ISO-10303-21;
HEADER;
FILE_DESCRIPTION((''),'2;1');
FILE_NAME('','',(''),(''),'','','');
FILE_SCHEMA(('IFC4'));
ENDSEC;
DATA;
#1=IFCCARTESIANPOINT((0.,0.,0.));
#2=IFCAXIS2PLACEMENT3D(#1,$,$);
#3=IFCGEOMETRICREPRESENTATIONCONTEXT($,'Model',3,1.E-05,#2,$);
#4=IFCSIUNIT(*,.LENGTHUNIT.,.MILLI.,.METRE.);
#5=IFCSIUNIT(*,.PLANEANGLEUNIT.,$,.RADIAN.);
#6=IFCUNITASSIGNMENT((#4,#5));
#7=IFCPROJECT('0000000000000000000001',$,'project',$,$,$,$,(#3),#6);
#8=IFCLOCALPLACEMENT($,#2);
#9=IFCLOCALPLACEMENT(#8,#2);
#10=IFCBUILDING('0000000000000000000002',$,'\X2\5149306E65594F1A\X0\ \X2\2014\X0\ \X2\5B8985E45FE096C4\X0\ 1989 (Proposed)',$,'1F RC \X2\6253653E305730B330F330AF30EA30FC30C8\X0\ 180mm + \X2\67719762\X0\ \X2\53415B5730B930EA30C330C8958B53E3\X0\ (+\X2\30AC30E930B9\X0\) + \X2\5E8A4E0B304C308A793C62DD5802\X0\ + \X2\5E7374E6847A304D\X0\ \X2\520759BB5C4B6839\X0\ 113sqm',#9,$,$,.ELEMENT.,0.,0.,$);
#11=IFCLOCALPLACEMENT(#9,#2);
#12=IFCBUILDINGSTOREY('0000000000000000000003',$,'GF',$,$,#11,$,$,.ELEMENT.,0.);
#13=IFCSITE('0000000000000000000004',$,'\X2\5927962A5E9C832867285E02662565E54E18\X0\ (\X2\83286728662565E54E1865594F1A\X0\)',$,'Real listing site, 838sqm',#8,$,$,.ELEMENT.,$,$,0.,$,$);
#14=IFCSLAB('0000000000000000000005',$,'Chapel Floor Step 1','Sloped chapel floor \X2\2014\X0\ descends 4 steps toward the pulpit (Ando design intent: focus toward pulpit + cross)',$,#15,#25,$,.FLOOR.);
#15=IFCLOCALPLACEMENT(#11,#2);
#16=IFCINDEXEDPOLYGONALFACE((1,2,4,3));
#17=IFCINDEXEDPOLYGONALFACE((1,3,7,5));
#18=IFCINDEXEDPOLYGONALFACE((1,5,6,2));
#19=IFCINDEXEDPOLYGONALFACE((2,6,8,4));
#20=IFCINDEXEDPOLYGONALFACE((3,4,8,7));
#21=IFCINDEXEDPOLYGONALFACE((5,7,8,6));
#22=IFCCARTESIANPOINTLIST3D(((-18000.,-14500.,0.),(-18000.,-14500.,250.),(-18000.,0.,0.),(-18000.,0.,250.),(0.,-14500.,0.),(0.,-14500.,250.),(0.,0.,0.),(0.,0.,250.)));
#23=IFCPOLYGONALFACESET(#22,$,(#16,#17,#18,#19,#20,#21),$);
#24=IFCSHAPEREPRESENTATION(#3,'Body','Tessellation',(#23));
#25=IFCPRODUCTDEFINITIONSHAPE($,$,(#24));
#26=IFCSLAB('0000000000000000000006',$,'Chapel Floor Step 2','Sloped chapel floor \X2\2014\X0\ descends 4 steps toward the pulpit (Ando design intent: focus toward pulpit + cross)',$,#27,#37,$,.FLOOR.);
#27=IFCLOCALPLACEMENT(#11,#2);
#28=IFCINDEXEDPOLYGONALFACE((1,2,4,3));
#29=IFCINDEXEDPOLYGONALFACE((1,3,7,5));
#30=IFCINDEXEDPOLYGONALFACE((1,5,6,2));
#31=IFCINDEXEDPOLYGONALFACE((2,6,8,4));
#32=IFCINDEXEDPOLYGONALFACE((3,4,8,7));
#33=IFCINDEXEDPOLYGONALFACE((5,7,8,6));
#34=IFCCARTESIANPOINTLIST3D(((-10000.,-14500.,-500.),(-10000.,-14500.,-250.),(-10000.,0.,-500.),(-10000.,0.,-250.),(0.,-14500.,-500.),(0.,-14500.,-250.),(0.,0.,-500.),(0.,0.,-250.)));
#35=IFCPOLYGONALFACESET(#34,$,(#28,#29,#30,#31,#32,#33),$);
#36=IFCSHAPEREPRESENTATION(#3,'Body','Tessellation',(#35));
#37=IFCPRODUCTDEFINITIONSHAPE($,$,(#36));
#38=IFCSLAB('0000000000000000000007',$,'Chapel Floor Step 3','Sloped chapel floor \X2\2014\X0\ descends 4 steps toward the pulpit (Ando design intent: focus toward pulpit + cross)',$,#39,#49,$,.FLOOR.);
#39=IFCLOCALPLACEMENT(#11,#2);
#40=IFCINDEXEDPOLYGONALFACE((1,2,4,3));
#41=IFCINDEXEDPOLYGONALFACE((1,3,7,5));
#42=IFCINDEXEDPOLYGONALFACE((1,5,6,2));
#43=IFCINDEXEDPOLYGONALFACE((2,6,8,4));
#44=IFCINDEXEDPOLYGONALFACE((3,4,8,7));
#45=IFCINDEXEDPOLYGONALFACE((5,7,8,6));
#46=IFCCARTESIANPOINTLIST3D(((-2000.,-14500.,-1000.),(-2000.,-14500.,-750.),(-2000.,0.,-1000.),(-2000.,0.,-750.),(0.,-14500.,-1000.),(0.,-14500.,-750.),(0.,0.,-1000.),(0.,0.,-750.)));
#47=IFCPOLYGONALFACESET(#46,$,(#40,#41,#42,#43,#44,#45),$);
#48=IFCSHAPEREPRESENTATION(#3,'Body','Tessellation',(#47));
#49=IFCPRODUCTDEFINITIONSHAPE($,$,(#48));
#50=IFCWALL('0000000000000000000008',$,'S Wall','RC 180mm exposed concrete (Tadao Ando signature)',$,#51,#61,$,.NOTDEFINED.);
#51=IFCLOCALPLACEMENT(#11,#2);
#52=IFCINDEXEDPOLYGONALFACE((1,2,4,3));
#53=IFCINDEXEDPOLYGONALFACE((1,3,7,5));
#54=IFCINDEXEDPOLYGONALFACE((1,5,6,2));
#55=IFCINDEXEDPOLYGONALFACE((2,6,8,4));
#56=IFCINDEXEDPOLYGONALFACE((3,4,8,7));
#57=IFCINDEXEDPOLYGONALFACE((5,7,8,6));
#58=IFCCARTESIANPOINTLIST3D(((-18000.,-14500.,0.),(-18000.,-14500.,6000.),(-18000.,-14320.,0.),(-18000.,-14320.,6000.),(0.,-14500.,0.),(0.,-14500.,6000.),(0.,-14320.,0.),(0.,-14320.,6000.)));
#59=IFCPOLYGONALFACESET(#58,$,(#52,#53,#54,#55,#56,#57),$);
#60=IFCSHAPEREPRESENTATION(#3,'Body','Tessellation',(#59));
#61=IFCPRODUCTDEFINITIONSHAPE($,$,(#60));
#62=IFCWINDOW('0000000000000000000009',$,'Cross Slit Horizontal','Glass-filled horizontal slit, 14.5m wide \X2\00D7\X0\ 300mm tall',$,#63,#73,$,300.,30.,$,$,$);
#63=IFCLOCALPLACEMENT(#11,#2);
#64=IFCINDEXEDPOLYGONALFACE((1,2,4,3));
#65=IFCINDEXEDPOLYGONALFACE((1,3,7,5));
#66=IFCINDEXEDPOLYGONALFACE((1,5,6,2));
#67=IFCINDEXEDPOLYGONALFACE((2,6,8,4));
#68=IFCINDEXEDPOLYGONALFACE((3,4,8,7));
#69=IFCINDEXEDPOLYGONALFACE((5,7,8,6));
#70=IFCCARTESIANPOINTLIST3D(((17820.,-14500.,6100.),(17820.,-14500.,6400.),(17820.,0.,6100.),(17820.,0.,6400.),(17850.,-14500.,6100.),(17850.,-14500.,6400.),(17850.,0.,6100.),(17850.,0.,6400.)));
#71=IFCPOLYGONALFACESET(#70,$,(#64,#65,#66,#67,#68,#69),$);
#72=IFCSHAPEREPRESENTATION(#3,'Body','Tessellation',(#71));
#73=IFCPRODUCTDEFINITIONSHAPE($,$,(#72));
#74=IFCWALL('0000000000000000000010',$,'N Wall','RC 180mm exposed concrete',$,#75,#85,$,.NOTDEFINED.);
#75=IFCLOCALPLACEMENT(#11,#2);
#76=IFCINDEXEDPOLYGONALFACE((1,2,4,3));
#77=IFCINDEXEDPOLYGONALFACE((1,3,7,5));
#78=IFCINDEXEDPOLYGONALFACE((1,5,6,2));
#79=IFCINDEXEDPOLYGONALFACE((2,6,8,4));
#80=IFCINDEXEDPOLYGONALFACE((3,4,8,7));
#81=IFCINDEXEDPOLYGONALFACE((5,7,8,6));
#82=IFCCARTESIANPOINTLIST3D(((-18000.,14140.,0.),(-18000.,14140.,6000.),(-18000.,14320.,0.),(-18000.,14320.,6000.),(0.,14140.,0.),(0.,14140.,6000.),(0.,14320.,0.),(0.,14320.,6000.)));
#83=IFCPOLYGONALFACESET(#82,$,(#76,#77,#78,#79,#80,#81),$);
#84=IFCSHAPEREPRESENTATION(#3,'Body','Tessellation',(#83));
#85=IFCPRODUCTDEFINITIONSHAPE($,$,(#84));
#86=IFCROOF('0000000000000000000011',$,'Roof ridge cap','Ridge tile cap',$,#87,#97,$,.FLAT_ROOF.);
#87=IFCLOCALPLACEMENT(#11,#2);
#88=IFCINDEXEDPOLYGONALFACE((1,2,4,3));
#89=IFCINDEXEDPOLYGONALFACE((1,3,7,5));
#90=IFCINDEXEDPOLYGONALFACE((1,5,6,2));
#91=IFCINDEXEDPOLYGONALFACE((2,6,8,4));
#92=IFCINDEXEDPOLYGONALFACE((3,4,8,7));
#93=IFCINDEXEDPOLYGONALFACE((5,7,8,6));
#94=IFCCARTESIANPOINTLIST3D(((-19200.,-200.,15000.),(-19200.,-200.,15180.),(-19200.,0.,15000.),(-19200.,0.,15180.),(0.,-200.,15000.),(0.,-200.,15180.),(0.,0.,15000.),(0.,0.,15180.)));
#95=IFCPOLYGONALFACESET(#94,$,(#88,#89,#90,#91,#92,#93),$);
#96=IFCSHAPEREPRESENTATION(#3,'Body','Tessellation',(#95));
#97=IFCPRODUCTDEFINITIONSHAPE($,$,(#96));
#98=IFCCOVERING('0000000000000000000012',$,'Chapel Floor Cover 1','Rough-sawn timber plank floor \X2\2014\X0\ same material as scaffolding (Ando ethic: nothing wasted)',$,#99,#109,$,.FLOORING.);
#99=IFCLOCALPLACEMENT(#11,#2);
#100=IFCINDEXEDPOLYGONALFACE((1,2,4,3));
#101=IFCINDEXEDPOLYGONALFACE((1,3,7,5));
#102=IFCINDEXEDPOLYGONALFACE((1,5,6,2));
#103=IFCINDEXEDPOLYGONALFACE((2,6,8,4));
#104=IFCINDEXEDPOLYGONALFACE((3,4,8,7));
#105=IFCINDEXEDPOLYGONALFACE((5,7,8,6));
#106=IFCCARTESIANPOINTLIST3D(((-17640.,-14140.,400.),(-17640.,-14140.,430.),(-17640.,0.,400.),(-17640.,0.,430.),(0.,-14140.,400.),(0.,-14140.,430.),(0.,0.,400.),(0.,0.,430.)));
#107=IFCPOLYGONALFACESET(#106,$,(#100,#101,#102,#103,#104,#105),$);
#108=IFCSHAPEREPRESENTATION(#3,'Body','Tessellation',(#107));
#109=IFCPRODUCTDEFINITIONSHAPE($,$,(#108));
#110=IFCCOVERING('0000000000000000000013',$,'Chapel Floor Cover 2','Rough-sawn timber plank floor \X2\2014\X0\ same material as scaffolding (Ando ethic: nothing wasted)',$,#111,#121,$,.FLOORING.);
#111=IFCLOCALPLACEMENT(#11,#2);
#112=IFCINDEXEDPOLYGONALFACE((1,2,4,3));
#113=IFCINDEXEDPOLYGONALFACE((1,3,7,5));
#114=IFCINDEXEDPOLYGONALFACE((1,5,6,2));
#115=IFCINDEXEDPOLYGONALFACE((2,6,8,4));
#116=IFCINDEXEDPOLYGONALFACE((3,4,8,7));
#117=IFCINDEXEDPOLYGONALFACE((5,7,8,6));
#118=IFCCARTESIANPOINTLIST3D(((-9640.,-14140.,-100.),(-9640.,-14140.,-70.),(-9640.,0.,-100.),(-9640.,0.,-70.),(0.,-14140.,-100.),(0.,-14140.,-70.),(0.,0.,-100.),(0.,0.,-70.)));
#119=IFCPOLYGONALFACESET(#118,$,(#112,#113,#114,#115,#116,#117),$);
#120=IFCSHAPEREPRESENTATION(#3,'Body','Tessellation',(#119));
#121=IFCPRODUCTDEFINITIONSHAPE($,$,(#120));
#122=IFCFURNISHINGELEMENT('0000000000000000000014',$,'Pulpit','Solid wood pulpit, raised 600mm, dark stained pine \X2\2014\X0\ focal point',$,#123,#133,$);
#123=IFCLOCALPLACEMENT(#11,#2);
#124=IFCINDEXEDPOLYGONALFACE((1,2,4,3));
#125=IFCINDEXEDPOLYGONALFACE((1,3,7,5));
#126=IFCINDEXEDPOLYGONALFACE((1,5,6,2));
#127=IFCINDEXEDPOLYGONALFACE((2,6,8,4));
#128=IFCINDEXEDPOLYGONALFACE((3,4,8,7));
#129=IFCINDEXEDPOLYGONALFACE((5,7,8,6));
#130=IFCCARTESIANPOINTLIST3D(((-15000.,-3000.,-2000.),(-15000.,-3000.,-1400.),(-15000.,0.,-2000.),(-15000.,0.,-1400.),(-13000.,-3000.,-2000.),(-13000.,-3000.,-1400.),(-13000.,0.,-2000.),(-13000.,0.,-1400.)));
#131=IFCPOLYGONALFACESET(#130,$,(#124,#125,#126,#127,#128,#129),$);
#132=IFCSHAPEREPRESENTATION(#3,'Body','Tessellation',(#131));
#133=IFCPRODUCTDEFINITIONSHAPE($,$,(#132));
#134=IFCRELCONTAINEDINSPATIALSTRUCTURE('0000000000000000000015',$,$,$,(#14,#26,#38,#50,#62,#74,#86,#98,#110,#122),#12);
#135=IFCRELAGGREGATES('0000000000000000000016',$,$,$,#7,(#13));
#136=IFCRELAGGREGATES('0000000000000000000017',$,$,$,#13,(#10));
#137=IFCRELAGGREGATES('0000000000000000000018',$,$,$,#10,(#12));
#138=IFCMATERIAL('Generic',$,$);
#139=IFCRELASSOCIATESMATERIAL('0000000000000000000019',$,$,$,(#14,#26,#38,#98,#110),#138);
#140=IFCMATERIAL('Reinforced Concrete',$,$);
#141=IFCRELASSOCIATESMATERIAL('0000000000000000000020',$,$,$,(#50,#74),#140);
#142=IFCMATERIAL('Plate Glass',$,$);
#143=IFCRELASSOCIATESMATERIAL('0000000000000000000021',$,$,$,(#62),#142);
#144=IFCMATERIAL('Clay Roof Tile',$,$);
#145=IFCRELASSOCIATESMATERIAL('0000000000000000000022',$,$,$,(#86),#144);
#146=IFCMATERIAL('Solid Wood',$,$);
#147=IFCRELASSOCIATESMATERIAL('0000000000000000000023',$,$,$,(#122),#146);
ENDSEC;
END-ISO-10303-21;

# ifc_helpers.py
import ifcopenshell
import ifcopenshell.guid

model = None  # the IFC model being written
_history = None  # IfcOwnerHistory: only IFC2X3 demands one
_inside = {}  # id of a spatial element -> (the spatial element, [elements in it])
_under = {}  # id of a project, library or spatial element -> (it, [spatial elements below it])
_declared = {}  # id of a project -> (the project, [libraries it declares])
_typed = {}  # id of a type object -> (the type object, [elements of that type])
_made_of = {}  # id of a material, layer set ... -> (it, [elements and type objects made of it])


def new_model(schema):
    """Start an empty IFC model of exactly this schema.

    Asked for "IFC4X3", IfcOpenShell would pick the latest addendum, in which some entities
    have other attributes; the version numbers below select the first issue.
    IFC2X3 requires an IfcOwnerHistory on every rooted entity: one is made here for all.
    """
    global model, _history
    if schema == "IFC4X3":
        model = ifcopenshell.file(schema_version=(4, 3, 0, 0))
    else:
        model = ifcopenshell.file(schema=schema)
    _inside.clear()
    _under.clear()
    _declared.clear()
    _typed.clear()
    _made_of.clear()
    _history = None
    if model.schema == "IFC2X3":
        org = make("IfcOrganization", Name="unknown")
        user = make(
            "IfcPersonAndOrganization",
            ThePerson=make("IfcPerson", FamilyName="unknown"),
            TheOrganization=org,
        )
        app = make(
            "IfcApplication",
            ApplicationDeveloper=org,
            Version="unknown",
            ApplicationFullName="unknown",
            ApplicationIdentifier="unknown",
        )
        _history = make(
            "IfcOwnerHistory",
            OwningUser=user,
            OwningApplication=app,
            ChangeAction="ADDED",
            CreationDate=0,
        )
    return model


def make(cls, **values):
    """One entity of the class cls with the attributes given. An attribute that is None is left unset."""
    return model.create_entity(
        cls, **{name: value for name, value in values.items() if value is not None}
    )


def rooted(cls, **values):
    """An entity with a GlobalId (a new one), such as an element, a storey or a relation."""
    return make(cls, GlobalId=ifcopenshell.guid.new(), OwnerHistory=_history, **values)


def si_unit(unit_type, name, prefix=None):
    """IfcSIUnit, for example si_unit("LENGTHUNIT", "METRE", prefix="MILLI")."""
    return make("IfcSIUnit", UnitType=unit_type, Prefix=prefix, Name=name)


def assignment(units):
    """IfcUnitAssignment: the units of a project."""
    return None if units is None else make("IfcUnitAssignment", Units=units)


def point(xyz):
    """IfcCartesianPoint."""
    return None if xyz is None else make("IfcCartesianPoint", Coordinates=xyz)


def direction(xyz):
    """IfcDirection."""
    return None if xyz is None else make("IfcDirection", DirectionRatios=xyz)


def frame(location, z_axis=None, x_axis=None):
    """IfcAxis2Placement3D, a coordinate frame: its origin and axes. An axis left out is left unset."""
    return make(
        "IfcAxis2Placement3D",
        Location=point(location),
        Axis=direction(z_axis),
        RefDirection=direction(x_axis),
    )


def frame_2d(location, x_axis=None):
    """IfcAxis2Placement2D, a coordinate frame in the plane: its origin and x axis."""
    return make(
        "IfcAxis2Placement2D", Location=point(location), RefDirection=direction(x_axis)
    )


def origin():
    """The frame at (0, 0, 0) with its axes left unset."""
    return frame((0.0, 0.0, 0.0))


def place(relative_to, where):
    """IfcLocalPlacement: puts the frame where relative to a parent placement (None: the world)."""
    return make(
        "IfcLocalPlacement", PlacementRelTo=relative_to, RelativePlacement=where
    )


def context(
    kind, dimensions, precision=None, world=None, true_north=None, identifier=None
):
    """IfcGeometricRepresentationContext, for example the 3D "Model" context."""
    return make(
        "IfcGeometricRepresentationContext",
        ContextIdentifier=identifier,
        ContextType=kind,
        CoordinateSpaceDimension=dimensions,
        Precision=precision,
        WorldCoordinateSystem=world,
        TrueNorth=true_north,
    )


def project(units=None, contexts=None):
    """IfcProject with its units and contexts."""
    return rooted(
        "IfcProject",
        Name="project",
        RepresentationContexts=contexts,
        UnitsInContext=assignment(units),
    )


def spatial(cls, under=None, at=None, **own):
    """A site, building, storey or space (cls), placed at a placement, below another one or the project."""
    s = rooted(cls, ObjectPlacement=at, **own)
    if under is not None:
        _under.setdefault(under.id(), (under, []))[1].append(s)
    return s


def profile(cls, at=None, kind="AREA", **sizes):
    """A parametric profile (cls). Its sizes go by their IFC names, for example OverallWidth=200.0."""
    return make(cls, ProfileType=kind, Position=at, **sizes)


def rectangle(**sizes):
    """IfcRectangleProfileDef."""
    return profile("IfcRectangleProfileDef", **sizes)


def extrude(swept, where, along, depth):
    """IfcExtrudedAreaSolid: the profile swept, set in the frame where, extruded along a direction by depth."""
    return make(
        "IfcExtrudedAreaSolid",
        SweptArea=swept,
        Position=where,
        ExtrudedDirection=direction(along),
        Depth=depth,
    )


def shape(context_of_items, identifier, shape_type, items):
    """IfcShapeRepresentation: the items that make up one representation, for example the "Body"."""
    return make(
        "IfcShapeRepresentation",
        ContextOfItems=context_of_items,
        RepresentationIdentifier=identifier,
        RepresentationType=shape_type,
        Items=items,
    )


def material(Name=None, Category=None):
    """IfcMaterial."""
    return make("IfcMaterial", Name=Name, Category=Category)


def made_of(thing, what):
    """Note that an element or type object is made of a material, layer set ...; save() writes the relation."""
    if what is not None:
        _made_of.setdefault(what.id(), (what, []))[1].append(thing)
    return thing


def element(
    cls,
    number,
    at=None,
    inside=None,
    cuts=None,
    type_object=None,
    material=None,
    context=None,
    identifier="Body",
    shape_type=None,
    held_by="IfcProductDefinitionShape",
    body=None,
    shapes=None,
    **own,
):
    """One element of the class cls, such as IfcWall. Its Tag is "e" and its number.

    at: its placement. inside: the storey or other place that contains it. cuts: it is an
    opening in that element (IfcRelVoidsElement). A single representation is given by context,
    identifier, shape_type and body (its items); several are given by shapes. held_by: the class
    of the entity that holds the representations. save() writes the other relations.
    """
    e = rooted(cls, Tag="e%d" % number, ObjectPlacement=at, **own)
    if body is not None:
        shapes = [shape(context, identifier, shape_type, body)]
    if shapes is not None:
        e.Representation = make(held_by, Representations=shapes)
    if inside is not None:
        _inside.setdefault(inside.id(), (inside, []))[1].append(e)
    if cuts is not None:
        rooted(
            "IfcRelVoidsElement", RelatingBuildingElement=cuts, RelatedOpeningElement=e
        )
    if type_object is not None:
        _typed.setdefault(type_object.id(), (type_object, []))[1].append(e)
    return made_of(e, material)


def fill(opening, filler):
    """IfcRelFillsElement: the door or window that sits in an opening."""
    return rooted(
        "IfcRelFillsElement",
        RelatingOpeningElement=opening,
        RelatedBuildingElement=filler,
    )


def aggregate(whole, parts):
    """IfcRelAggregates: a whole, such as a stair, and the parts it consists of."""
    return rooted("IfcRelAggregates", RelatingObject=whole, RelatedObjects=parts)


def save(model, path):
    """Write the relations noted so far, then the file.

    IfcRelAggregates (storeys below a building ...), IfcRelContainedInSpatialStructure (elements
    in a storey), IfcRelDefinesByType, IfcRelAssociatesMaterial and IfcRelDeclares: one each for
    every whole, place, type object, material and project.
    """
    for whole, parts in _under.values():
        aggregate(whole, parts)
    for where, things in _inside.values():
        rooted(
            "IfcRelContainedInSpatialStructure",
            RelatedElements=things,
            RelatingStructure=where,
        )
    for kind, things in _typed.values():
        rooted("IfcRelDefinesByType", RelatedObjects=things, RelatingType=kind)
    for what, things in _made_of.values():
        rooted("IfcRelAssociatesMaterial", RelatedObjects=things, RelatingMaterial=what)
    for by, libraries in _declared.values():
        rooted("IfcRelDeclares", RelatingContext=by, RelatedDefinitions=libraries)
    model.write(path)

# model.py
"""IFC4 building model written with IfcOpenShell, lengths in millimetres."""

from ifc_helpers import new_model, si_unit, frame, frame_2d, origin, place, context, project, spatial, rectangle, extrude, material, element, fill, save


model = new_model("IFC4")

# Units and contexts
model_context = context("Model", 3, precision=1e-05, world=origin())
ifc_project = project(units=[si_unit("LENGTHUNIT", "METRE", prefix="MILLI"), si_unit("PLANEANGLEUNIT", "RADIAN")], contexts=[model_context])

# Site, building, storey
site_placement = place(None, origin())
site = spatial("IfcSite", under=ifc_project, at=site_placement, Name="大阪府茨木市春日丘 (茨木春日丘教会)", ObjectType="Real listing site, 838sqm", CompositionType="ELEMENT", RefElevation=0.0)
building_placement = place(site_placement, origin())
building = spatial("IfcBuilding", under=site, at=building_placement, Name="光の教会 — 安藤忠雄 1989 (Proposed)", ObjectType="1F RC 打放しコンクリート 180mm + 東面 十字スリット開口 (+ガラス) + 床下がり礼拝堂 + 平瓦葺き 切妻屋根 113sqm", CompositionType="ELEMENT", ElevationOfRefHeight=0.0, ElevationOfTerrain=0.0)
storey_placement = place(building_placement, origin())
storey = spatial("IfcBuildingStorey", under=building, at=storey_placement, Name="GF", CompositionType="ELEMENT", Elevation=0.0)

# Slabs
ifc_material_1 = material(Name="Generic")
slab_1_placement = place(storey_placement, frame((-9000.0, -7250.0, 0.0)))
element("IfcSlab", 1, at=slab_1_placement, inside=storey, material=ifc_material_1, Name="Chapel Floor Step 1", Description="Sloped chapel floor — descends 4 steps toward the pulpit (Ando design intent: focus toward pulpit + cross)", PredefinedType="FLOOR", context=model_context, shape_type="SweptSolid", body=[
    extrude(rectangle(XDim=18000.0, YDim=14500.0, at=frame_2d((9000.0, 7250.0))), frame((-9000.0, -7250.0, 0.0)), (0.0, 0.0, 1.0), 250.0),
])
slab_2_placement = place(storey_placement, frame((-5000.0, -7250.0, -250.0)))
element("IfcSlab", 2, at=slab_2_placement, inside=storey, material=ifc_material_1, Name="Chapel Floor Step 2", Description="Sloped chapel floor — descends 4 steps toward the pulpit (Ando design intent: focus toward pulpit + cross)", PredefinedType="FLOOR", context=model_context, shape_type="SweptSolid", body=[
    extrude(rectangle(XDim=10000.0, YDim=14500.0, at=frame_2d((5000.0, 7250.0))), frame((-5000.0, -7250.0, -250.0)), (0.0, 0.0, 1.0), 250.0),
])
slab_3_placement = place(storey_placement, frame((-1000.0, -7250.0, -500.0)))
element("IfcSlab", 3, at=slab_3_placement, inside=storey, material=ifc_material_1, Name="Chapel Floor Step 3", Description="Sloped chapel floor — descends 4 steps toward the pulpit (Ando design intent: focus toward pulpit + cross)", PredefinedType="FLOOR", context=model_context, shape_type="SweptSolid", body=[
    extrude(rectangle(XDim=2000.0, YDim=14500.0, at=frame_2d((1000.0, 7250.0))), frame((-1000.0, -7250.0, -500.0)), (0.0, 0.0, 1.0), 250.0),
])

# Wall, opening, window
ifc_material_2 = material(Name="Reinforced Concrete")
wall_1_placement = place(storey_placement, frame((-9000.0, -7250.0, 0.0)))
wall_1 = element("IfcWall", 4, at=wall_1_placement, inside=storey, material=ifc_material_2, Name="S Wall", Description="RC 180mm exposed concrete (Tadao Ando signature)", PredefinedType="NOTDEFINED", context=model_context, shape_type="SweptSolid", body=[
    extrude(rectangle(XDim=18000.0, YDim=180.0, at=frame_2d((9000.0, 90.0))), frame((-9000.0, -7250.0, 0.0)), (0.0, 0.0, 1.0), 6000.0),
])
opening_1_placement = place(storey_placement, frame((8910.0, -7250.0, 3050.0)))
opening_1 = element("IfcOpeningElement", 5, at=opening_1_placement, cuts=wall_1, PredefinedType="NOTDEFINED", context=model_context, shape_type="SweptSolid", body=[
    extrude(rectangle(XDim=30.0, YDim=14500.0, at=frame_2d((15.0, 7250.0))), frame((8910.0, -7250.0, 3050.0)), (0.0, 0.0, 1.0), 300.0),
])
ifc_material_3 = material(Name="Plate Glass")
window_placement = place(storey_placement, frame((8910.0, -7250.0, 3050.0)))
window = element("IfcWindow", 6, at=window_placement, inside=storey, material=ifc_material_3, Name="Cross Slit Horizontal", Description="Glass-filled horizontal slit, 14.5m wide × 300mm tall", OverallHeight=300.0, OverallWidth=30.0, context=model_context, shape_type="SweptSolid", body=[
    extrude(rectangle(XDim=30.0, YDim=14500.0, at=frame_2d((15.0, 7250.0))), frame((8910.0, -7250.0, 3050.0)), (0.0, 0.0, 1.0), 300.0),
])
fill(opening_1, window)

# Wall
wall_2_placement = place(storey_placement, frame((-9000.0, 7070.0, 0.0)))
element("IfcWall", 7, at=wall_2_placement, inside=storey, material=ifc_material_2, Name="N Wall", Description="RC 180mm exposed concrete", PredefinedType="NOTDEFINED", context=model_context, shape_type="SweptSolid", body=[
    extrude(rectangle(XDim=18000.0, YDim=180.0, at=frame_2d((9000.0, 90.0))), frame((-9000.0, 7070.0, 0.0)), (0.0, 0.0, 1.0), 6000.0),
])

# Shared definitions
ifc_material_4 = material(Name="Solid Wood")

# Roof
ifc_material_5 = material(Name="Clay Roof Tile")
roof_1_placement = place(storey_placement, frame((-9600.0, -100.0, 7500.0)))
element("IfcRoof", 8, at=roof_1_placement, inside=storey, material=ifc_material_5, Name="Roof ridge cap", Description="Ridge tile cap", PredefinedType="FLAT_ROOF", context=model_context, shape_type="SweptSolid", body=[
    extrude(rectangle(XDim=19200.0, YDim=200.0, at=frame_2d((9600.0, 100.0))), frame((-9600.0, -100.0, 7500.0)), (0.0, 0.0, 1.0), 180.0),
])

# Coverings
covering_1_placement = place(storey_placement, frame((-8820.0, -7070.0, 200.0)))
element("IfcCovering", 9, at=covering_1_placement, inside=storey, material=ifc_material_1, Name="Chapel Floor Cover 1", Description="Rough-sawn timber plank floor — same material as scaffolding (Ando ethic: nothing wasted)", PredefinedType="FLOORING", context=model_context, shape_type="SweptSolid", body=[
    extrude(rectangle(XDim=17640.0, YDim=14140.0, at=frame_2d((8820.0, 7070.0))), frame((-8820.0, -7070.0, 200.0)), (0.0, 0.0, 1.0), 30.0),
])
covering_2_placement = place(storey_placement, frame((-4820.0, -7070.0, -50.0)))
element("IfcCovering", 10, at=covering_2_placement, inside=storey, material=ifc_material_1, Name="Chapel Floor Cover 2", Description="Rough-sawn timber plank floor — same material as scaffolding (Ando ethic: nothing wasted)", PredefinedType="FLOORING", context=model_context, shape_type="SweptSolid", body=[
    extrude(rectangle(XDim=9640.0, YDim=14140.0, at=frame_2d((4820.0, 7070.0))), frame((-4820.0, -7070.0, -50.0)), (0.0, 0.0, 1.0), 30.0),
])

# Furnishing element
furnishing_1_placement = place(storey_placement, frame((-7500.0, -1500.0, -1000.0)))
element("IfcFurnishingElement", 11, at=furnishing_1_placement, inside=storey, material=ifc_material_4, Name="Pulpit", Description="Solid wood pulpit, raised 600mm, dark stained pine — focal point", context=model_context, shape_type="SweptSolid", body=[
    extrude(rectangle(XDim=2000.0, YDim=3000.0, at=frame_2d((1000.0, 1500.0))), frame((-7500.0, -1500.0, -1000.0)), (0.0, 0.0, 1.0), 600.0),
])

save(model, "model.ifc")
